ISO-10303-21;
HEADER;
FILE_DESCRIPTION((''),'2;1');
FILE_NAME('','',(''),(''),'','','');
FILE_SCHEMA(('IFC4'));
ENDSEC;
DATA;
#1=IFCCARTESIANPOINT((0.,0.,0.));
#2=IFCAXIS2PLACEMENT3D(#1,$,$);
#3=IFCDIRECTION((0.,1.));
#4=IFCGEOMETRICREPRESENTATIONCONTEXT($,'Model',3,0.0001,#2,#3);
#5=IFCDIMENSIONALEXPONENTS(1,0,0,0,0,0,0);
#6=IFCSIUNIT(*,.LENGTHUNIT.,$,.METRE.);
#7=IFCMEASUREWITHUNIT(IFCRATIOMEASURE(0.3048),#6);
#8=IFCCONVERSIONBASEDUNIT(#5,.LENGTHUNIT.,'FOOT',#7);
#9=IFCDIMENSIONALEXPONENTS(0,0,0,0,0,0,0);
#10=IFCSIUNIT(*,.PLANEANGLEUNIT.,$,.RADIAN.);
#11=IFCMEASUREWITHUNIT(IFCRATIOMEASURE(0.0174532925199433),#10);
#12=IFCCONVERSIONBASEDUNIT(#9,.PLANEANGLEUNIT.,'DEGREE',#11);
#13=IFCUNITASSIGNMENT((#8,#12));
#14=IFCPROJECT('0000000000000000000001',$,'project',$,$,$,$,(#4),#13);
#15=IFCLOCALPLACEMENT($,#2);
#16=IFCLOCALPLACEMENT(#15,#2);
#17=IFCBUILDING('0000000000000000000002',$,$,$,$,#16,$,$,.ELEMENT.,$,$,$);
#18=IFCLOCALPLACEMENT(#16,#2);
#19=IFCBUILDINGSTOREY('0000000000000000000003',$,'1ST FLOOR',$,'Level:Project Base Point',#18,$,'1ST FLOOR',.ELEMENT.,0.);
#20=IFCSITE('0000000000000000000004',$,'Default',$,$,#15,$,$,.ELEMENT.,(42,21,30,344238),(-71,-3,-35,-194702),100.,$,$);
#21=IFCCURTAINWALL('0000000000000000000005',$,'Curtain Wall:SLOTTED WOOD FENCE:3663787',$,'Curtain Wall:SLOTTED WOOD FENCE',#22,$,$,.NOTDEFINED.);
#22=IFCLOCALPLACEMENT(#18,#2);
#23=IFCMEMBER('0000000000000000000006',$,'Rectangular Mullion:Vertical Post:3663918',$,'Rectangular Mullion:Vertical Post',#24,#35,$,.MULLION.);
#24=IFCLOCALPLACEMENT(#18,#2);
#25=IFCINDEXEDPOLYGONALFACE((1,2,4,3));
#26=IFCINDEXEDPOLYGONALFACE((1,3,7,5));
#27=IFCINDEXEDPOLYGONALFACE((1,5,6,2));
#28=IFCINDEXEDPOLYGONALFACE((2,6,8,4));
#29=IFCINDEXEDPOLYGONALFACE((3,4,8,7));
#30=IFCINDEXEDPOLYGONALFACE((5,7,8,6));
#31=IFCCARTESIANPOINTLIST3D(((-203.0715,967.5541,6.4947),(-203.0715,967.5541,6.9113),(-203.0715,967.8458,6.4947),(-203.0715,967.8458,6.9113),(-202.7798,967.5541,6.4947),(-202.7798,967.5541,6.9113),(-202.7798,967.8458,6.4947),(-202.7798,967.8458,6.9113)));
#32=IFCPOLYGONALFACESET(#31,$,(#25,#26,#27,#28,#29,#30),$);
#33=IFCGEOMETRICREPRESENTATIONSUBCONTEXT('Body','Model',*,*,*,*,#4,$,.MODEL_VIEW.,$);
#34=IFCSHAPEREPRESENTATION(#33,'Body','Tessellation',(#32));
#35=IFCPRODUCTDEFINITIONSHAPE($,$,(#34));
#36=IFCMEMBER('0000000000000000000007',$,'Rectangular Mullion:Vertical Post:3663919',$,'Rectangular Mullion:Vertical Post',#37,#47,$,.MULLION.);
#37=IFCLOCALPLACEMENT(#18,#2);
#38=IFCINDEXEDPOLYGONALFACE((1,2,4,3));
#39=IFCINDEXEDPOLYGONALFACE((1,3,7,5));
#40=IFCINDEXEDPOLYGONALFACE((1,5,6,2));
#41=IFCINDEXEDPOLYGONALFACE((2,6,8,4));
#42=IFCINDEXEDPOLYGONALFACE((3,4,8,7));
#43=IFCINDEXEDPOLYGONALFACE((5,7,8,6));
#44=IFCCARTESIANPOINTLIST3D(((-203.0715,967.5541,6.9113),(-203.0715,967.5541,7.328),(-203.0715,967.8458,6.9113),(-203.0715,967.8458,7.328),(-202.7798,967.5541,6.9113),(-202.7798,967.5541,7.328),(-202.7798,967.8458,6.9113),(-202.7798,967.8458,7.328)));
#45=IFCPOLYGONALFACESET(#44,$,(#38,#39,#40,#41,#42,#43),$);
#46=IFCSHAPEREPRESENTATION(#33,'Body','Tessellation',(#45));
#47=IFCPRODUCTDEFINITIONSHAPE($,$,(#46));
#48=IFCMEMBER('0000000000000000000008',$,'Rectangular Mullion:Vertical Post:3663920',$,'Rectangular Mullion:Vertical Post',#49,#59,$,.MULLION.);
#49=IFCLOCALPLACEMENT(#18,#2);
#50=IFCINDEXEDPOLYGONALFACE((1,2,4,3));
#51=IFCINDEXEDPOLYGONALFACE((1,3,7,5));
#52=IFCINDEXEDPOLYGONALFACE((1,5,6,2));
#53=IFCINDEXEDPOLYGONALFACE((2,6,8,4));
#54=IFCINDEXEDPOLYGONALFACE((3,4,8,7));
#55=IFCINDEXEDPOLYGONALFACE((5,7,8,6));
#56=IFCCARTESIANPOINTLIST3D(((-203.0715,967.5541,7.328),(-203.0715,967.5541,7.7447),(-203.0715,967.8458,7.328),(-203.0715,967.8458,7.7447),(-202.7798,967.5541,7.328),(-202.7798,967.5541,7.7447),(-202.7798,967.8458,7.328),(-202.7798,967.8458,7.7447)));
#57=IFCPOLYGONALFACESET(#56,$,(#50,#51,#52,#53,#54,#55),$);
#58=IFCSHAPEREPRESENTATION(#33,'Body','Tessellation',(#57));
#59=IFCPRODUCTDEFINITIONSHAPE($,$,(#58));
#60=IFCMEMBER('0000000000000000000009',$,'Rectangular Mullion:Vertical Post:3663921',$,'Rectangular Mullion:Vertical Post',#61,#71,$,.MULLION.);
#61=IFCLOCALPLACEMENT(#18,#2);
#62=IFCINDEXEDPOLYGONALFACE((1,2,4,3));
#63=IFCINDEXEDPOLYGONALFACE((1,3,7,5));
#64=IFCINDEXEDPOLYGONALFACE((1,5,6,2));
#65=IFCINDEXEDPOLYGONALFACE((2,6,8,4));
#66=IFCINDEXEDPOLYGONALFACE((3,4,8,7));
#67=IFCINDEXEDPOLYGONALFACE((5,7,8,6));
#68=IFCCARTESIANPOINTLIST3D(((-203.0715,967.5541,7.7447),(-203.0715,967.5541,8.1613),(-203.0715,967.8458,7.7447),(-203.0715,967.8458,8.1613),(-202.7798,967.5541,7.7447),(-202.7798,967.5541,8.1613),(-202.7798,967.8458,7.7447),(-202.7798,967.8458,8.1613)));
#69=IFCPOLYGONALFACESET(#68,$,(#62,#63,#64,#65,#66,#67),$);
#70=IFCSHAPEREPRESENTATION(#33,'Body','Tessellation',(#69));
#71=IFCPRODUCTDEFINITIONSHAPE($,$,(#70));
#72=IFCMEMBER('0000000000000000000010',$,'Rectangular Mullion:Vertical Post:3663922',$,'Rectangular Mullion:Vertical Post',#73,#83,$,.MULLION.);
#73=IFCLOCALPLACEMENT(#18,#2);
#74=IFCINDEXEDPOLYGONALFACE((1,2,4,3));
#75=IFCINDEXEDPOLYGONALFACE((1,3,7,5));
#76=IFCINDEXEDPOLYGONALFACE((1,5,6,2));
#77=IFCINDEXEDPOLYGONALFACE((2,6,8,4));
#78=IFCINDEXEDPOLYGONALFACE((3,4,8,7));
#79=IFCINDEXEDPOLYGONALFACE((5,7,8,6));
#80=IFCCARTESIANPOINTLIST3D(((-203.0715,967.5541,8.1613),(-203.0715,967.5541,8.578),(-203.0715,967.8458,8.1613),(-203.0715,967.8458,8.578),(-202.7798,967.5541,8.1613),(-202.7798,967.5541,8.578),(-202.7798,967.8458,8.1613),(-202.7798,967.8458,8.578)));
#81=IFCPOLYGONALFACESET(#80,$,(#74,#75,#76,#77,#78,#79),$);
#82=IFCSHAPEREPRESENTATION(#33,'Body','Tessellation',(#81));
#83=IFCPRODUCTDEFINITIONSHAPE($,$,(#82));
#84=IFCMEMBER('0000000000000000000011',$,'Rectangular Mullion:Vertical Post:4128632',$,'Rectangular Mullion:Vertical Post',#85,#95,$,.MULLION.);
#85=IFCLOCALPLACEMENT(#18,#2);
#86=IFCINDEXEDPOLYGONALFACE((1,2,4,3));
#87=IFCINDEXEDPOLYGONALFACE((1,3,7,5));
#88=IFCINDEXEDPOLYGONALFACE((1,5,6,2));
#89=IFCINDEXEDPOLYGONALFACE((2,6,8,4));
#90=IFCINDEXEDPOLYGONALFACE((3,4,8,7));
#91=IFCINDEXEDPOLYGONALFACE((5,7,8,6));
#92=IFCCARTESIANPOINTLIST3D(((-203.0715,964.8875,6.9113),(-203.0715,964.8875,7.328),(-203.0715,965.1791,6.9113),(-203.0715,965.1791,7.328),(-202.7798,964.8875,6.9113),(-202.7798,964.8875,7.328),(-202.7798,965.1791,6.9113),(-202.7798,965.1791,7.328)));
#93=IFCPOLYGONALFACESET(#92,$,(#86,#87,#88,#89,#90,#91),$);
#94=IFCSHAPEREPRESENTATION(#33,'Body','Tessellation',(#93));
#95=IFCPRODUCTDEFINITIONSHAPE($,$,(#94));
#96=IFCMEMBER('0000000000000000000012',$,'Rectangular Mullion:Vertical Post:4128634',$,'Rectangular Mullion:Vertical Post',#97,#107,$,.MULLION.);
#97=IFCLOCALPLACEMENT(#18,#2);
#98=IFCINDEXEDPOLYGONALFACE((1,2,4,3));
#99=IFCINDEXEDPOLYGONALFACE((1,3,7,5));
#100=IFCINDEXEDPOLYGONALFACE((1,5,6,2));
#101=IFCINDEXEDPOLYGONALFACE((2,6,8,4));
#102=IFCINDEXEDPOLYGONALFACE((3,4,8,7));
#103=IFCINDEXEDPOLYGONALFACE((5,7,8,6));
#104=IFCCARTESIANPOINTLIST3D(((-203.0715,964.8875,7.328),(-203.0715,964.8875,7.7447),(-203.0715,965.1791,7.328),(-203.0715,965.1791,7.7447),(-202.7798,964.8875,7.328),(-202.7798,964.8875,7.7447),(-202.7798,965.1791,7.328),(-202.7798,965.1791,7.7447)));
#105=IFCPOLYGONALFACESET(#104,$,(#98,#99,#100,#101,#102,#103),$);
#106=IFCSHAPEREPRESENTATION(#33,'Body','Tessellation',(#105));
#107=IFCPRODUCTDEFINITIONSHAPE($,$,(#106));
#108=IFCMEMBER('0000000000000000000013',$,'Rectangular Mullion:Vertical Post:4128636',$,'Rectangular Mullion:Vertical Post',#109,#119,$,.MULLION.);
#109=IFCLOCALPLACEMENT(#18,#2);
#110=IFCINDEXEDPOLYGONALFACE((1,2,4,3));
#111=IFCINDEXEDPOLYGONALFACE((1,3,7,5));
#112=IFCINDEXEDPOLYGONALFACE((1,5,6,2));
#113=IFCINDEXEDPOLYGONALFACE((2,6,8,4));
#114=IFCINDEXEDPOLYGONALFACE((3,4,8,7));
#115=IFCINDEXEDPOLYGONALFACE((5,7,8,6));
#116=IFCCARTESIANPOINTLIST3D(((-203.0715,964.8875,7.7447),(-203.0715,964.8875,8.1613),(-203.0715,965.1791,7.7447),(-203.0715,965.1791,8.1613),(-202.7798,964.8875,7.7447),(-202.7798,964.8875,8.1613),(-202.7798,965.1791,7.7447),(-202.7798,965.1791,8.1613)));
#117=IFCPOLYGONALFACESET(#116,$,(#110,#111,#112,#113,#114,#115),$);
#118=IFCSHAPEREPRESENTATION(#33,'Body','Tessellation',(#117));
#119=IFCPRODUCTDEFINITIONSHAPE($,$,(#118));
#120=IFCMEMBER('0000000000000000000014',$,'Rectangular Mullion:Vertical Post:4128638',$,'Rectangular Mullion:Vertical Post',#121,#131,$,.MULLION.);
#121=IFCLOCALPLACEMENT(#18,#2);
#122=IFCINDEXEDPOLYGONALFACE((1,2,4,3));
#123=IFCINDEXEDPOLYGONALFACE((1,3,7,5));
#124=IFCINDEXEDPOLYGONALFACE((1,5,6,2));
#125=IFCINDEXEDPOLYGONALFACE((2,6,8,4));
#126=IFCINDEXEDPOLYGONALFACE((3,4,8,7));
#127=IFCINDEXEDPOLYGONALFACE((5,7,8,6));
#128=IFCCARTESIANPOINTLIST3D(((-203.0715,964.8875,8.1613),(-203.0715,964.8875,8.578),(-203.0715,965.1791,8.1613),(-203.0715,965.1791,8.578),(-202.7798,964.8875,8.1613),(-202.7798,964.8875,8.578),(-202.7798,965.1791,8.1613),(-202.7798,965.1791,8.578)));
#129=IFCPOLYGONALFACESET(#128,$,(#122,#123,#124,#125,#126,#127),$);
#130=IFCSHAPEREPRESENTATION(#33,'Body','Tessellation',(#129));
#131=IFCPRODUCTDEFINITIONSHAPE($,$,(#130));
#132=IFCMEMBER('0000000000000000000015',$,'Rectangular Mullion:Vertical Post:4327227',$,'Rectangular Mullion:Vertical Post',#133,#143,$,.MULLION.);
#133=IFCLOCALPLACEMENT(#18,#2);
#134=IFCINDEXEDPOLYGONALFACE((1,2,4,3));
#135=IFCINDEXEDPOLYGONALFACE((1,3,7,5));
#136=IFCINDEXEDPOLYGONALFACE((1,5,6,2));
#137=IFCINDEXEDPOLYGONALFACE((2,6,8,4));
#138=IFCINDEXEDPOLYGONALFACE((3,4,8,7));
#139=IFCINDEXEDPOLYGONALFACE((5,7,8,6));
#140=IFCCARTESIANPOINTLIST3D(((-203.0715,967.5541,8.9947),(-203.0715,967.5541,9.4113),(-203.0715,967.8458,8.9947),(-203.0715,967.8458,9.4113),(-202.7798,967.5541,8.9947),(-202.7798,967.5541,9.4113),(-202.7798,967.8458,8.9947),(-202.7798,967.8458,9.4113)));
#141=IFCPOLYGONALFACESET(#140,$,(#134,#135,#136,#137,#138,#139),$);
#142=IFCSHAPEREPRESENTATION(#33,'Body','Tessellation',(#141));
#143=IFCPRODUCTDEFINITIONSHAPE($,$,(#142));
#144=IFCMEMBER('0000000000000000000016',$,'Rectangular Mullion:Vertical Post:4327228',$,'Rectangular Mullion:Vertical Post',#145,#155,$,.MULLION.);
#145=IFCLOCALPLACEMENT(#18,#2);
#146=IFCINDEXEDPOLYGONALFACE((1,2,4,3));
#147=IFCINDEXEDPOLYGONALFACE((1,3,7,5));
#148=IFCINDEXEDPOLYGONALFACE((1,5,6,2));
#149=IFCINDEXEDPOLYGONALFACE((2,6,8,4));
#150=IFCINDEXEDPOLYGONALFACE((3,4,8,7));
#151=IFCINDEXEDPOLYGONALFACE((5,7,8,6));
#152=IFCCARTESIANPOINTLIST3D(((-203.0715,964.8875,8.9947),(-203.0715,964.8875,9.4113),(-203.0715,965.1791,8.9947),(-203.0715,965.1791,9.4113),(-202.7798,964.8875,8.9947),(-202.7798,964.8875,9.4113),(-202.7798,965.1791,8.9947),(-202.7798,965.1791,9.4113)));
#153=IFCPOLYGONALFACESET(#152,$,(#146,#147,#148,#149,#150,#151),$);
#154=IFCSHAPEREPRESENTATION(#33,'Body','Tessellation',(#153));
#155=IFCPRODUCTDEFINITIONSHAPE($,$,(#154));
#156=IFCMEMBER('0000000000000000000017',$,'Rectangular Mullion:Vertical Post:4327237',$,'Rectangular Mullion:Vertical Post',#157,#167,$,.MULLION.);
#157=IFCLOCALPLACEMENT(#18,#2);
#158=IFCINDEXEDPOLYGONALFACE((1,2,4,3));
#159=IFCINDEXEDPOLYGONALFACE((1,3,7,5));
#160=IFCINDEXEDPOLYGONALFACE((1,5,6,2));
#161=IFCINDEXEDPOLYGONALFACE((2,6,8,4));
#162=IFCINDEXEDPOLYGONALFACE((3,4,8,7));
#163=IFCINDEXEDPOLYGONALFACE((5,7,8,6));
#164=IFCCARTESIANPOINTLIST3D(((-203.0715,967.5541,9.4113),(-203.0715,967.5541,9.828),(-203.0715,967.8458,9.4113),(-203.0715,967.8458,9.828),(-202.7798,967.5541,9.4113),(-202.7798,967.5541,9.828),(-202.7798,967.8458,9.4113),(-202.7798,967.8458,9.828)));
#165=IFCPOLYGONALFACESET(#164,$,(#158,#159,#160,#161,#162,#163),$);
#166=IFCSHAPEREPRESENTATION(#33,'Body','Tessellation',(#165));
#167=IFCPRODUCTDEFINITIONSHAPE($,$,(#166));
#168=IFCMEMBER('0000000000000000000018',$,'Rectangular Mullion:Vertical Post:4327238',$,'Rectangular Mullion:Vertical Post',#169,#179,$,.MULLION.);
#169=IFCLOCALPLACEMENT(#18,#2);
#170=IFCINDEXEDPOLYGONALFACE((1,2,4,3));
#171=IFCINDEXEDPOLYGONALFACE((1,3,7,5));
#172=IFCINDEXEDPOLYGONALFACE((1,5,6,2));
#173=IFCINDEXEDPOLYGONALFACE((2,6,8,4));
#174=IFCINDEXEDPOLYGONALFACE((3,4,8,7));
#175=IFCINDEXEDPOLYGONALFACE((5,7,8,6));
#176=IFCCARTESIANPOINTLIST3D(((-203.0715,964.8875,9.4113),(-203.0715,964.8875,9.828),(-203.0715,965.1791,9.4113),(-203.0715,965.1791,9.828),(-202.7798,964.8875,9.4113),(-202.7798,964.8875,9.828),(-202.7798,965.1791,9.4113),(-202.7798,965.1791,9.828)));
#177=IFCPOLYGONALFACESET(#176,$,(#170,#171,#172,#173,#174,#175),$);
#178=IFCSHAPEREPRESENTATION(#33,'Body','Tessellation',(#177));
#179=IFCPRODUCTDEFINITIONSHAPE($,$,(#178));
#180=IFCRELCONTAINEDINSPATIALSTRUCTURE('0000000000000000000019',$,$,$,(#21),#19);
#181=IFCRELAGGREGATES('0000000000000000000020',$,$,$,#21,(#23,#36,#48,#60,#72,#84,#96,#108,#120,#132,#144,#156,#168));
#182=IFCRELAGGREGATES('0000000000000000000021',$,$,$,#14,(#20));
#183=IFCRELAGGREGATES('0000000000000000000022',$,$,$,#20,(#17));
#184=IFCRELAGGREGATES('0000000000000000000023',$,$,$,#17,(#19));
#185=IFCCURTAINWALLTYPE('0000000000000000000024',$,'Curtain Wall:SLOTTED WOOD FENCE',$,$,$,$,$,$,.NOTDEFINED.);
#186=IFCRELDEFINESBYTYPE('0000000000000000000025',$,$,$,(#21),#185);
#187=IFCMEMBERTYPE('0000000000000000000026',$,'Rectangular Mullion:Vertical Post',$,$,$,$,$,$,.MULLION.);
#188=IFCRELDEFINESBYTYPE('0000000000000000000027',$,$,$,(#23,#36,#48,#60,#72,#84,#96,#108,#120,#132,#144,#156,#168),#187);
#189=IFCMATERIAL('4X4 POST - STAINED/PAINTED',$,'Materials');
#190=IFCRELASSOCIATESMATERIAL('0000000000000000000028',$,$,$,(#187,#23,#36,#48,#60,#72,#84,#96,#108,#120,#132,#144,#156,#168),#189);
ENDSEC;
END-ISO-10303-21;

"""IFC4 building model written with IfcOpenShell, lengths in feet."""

from ifc_helpers import new_model, entity, si_unit, converted_unit, direction, frame, origin, origin_2d_with_axis, place, context, subcontext, project, spatial, rectangle, extrude, source, transform, mapped, material, material_profile, profile_set, profile_usage, type_object, type_shapes, element, aggregate, save


model = new_model("IFC4")

# Units and contexts
model_context = context("Model", 3, precision=0.0001, world=origin(), true_north=direction((0.0, 1.0)))
body_context = subcontext(model_context, "Body", "Model", "MODEL_VIEW")
ifc_project = project(units=[converted_unit("LENGTHUNIT", "FOOT", entity("IfcRatioMeasure", 0.3048), si_unit("LENGTHUNIT", "METRE"), dimensions=[1, 0, 0, 0, 0, 0, 0]), converted_unit("PLANEANGLEUNIT", "DEGREE", entity("IfcRatioMeasure", 0.0174532925199433), si_unit("PLANEANGLEUNIT", "RADIAN"), dimensions=[0, 0, 0, 0, 0, 0, 0])], contexts=[model_context])

# Site, building, storey
site_placement = place(None, origin())
site = spatial("IfcSite", under=ifc_project, at=site_placement, Name="Default", CompositionType="ELEMENT", RefLatitude=(42, 21, 30, 344238), RefLongitude=(-71, -3, -35, -194702), RefElevation=100.0)
building_placement = place(site_placement, origin())
building = spatial("IfcBuilding", under=site, at=building_placement, CompositionType="ELEMENT")
storey_placement = place(building_placement, origin())
storey = spatial("IfcBuildingStorey", under=building, at=storey_placement, Name="1ST FLOOR", ObjectType="Level:Project Base Point", LongName="1ST FLOOR", CompositionType="ELEMENT", Elevation=0.0)

# Curtain wall, members
curtain_wall_type = type_object("IfcCurtainWallType", Name="Curtain Wall:SLOTTED WOOD FENCE", PredefinedType="NOTDEFINED")
curtain_wall_placement = place(storey_placement, origin())
curtain_wall = element("IfcCurtainWall", 1, at=curtain_wall_placement, inside=storey, type_object=curtain_wall_type, Name="Curtain Wall:SLOTTED WOOD FENCE:3663787", ObjectType="Curtain Wall:SLOTTED WOOD FENCE", PredefinedType="NOTDEFINED")
ifc_material_1 = material(Name="4X4 POST - STAINED/PAINTED", Category="Materials")
ifc_material_profile = material_profile(ifc_material_1, rectangle(XDim=0.2917, YDim=0.2917, at=origin_2d_with_axis()), Name="Vertical Post")
ifc_profile_set = profile_set([ifc_material_profile], Name="Vertical Post")
ifc_profile_usage_1 = profile_usage(ifc_profile_set)
member_type_1 = type_object("IfcMemberType", Name="Rectangular Mullion:Vertical Post", PredefinedType="MULLION", material=ifc_profile_set)
shared_shape_1 = source(origin(), body_context, "Body", "SweptSolid", [
    extrude(rectangle(XDim=0.2917, YDim=0.2917, at=origin_2d_with_axis()), frame((0.0, -0.2083, -0.4167), z_axis=(0.0, 0.0, 1.0), x_axis=(0.0, -1.0, 0.0)), (0.0, 0.0, 1.0), 0.4167),
])
type_shapes(member_type_1, [shared_shape_1])
member_1_placement = place(storey_placement, frame((-203.134, 967.7, 6.4947), z_axis=(0.0, 0.0, -1.0), x_axis=(0.0, -1.0, 0.0)))
member_1 = element("IfcMember", 2, at=member_1_placement, type_object=member_type_1, material=ifc_profile_usage_1, Name="Rectangular Mullion:Vertical Post:3663918", ObjectType="Rectangular Mullion:Vertical Post", PredefinedType="MULLION", context=body_context, shape_type="MappedRepresentation", body=[
    mapped(shared_shape_1, transform((0.0, 0.0, 0.0), scale=1.0)),
])
ifc_profile_usage_2 = profile_usage(ifc_profile_set)
member_2_placement = place(storey_placement, frame((-203.134, 967.7, 6.9113), z_axis=(0.0, 0.0, -1.0), x_axis=(0.0, -1.0, 0.0)))
member_2 = element("IfcMember", 3, at=member_2_placement, type_object=member_type_1, material=ifc_profile_usage_2, Name="Rectangular Mullion:Vertical Post:3663919", ObjectType="Rectangular Mullion:Vertical Post", PredefinedType="MULLION", context=body_context, shape_type="MappedRepresentation", body=[
    mapped(shared_shape_1, transform((0.0, 0.0, 0.0), scale=1.0)),
])
ifc_profile_usage_3 = profile_usage(ifc_profile_set)
member_3_placement = place(storey_placement, frame((-203.134, 967.7, 7.328), z_axis=(0.0, 0.0, -1.0), x_axis=(0.0, -1.0, 0.0)))
member_3 = element("IfcMember", 4, at=member_3_placement, type_object=member_type_1, material=ifc_profile_usage_3, Name="Rectangular Mullion:Vertical Post:3663920", ObjectType="Rectangular Mullion:Vertical Post", PredefinedType="MULLION", context=body_context, shape_type="MappedRepresentation", body=[
    mapped(shared_shape_1, transform((0.0, 0.0, 0.0), scale=1.0)),
])
ifc_profile_usage_4 = profile_usage(ifc_profile_set)
member_4_placement = place(storey_placement, frame((-203.134, 967.7, 7.7447), z_axis=(0.0, 0.0, -1.0), x_axis=(0.0, -1.0, 0.0)))
member_4 = element("IfcMember", 5, at=member_4_placement, type_object=member_type_1, material=ifc_profile_usage_4, Name="Rectangular Mullion:Vertical Post:3663921", ObjectType="Rectangular Mullion:Vertical Post", PredefinedType="MULLION", context=body_context, shape_type="MappedRepresentation", body=[
    mapped(shared_shape_1, transform((0.0, 0.0, 0.0), scale=1.0)),
])
ifc_profile_usage_5 = profile_usage(ifc_profile_set)
member_5_placement = place(storey_placement, frame((-203.134, 967.7, 8.1613), z_axis=(0.0, 0.0, -1.0), x_axis=(0.0, -1.0, 0.0)))
member_5 = element("IfcMember", 6, at=member_5_placement, type_object=member_type_1, material=ifc_profile_usage_5, Name="Rectangular Mullion:Vertical Post:3663922", ObjectType="Rectangular Mullion:Vertical Post", PredefinedType="MULLION", context=body_context, shape_type="MappedRepresentation", body=[
    mapped(shared_shape_1, transform((0.0, 0.0, 0.0), scale=1.0)),
])
ifc_profile_usage_6 = profile_usage(ifc_profile_set)
member_6_placement = place(storey_placement, frame((-203.134, 965.0333, 6.9113), z_axis=(0.0, 0.0, -1.0), x_axis=(0.0, -1.0, 0.0)))
member_6 = element("IfcMember", 7, at=member_6_placement, type_object=member_type_1, material=ifc_profile_usage_6, Name="Rectangular Mullion:Vertical Post:4128632", ObjectType="Rectangular Mullion:Vertical Post", PredefinedType="MULLION", context=body_context, shape_type="MappedRepresentation", body=[
    mapped(shared_shape_1, transform((0.0, 0.0, 0.0), scale=1.0)),
])
ifc_profile_usage_7 = profile_usage(ifc_profile_set)
member_7_placement = place(storey_placement, frame((-203.134, 965.0333, 7.328), z_axis=(0.0, 0.0, -1.0), x_axis=(0.0, -1.0, 0.0)))
member_7 = element("IfcMember", 8, at=member_7_placement, type_object=member_type_1, material=ifc_profile_usage_7, Name="Rectangular Mullion:Vertical Post:4128634", ObjectType="Rectangular Mullion:Vertical Post", PredefinedType="MULLION", context=body_context, shape_type="MappedRepresentation", body=[
    mapped(shared_shape_1, transform((0.0, 0.0, 0.0), scale=1.0)),
])
ifc_profile_usage_8 = profile_usage(ifc_profile_set)
member_8_placement = place(storey_placement, frame((-203.134, 965.0333, 7.7447), z_axis=(0.0, 0.0, -1.0), x_axis=(0.0, -1.0, 0.0)))
member_8 = element("IfcMember", 9, at=member_8_placement, type_object=member_type_1, material=ifc_profile_usage_8, Name="Rectangular Mullion:Vertical Post:4128636", ObjectType="Rectangular Mullion:Vertical Post", PredefinedType="MULLION", context=body_context, shape_type="MappedRepresentation", body=[
    mapped(shared_shape_1, transform((0.0, 0.0, 0.0), scale=1.0)),
])
ifc_profile_usage_9 = profile_usage(ifc_profile_set)
member_9_placement = place(storey_placement, frame((-203.134, 965.0333, 8.1613), z_axis=(0.0, 0.0, -1.0), x_axis=(0.0, -1.0, 0.0)))
member_9 = element("IfcMember", 10, at=member_9_placement, type_object=member_type_1, material=ifc_profile_usage_9, Name="Rectangular Mullion:Vertical Post:4128638", ObjectType="Rectangular Mullion:Vertical Post", PredefinedType="MULLION", context=body_context, shape_type="MappedRepresentation", body=[
    mapped(shared_shape_1, transform((0.0, 0.0, 0.0), scale=1.0)),
])
ifc_profile_usage_10 = profile_usage(ifc_profile_set)
member_10_placement = place(storey_placement, frame((-203.134, 967.7, 8.9947), z_axis=(0.0, 0.0, -1.0), x_axis=(0.0, -1.0, 0.0)))
member_10 = element("IfcMember", 11, at=member_10_placement, type_object=member_type_1, material=ifc_profile_usage_10, Name="Rectangular Mullion:Vertical Post:4327227", ObjectType="Rectangular Mullion:Vertical Post", PredefinedType="MULLION", context=body_context, shape_type="MappedRepresentation", body=[
    mapped(shared_shape_1, transform((0.0, 0.0, 0.0), scale=1.0)),
])
ifc_profile_usage_11 = profile_usage(ifc_profile_set)
member_11_placement = place(storey_placement, frame((-203.134, 965.0333, 8.9947), z_axis=(0.0, 0.0, -1.0), x_axis=(0.0, -1.0, 0.0)))
member_11 = element("IfcMember", 12, at=member_11_placement, type_object=member_type_1, material=ifc_profile_usage_11, Name="Rectangular Mullion:Vertical Post:4327228", ObjectType="Rectangular Mullion:Vertical Post", PredefinedType="MULLION", context=body_context, shape_type="MappedRepresentation", body=[
    mapped(shared_shape_1, transform((0.0, 0.0, 0.0), scale=1.0)),
])
ifc_profile_usage_12 = profile_usage(ifc_profile_set)
member_12_placement = place(storey_placement, frame((-203.134, 967.7, 9.4113), z_axis=(0.0, 0.0, -1.0), x_axis=(0.0, -1.0, 0.0)))
member_12 = element("IfcMember", 13, at=member_12_placement, type_object=member_type_1, material=ifc_profile_usage_12, Name="Rectangular Mullion:Vertical Post:4327237", ObjectType="Rectangular Mullion:Vertical Post", PredefinedType="MULLION", context=body_context, shape_type="MappedRepresentation", body=[
    mapped(shared_shape_1, transform((0.0, 0.0, 0.0), scale=1.0)),
])
ifc_profile_usage_13 = profile_usage(ifc_profile_set)
member_13_placement = place(storey_placement, frame((-203.134, 965.0333, 9.4113), z_axis=(0.0, 0.0, -1.0), x_axis=(0.0, -1.0, 0.0)))
member_13 = element("IfcMember", 14, at=member_13_placement, type_object=member_type_1, material=ifc_profile_usage_13, Name="Rectangular Mullion:Vertical Post:4327238", ObjectType="Rectangular Mullion:Vertical Post", PredefinedType="MULLION", context=body_context, shape_type="MappedRepresentation", body=[
    mapped(shared_shape_1, transform((0.0, 0.0, 0.0), scale=1.0)),
])
aggregate(curtain_wall, [member_1, member_2, member_3, member_4, member_5, member_6, member_7, member_8, member_9, member_10, member_11, member_12, member_13])

save(model, "model.ifc")
